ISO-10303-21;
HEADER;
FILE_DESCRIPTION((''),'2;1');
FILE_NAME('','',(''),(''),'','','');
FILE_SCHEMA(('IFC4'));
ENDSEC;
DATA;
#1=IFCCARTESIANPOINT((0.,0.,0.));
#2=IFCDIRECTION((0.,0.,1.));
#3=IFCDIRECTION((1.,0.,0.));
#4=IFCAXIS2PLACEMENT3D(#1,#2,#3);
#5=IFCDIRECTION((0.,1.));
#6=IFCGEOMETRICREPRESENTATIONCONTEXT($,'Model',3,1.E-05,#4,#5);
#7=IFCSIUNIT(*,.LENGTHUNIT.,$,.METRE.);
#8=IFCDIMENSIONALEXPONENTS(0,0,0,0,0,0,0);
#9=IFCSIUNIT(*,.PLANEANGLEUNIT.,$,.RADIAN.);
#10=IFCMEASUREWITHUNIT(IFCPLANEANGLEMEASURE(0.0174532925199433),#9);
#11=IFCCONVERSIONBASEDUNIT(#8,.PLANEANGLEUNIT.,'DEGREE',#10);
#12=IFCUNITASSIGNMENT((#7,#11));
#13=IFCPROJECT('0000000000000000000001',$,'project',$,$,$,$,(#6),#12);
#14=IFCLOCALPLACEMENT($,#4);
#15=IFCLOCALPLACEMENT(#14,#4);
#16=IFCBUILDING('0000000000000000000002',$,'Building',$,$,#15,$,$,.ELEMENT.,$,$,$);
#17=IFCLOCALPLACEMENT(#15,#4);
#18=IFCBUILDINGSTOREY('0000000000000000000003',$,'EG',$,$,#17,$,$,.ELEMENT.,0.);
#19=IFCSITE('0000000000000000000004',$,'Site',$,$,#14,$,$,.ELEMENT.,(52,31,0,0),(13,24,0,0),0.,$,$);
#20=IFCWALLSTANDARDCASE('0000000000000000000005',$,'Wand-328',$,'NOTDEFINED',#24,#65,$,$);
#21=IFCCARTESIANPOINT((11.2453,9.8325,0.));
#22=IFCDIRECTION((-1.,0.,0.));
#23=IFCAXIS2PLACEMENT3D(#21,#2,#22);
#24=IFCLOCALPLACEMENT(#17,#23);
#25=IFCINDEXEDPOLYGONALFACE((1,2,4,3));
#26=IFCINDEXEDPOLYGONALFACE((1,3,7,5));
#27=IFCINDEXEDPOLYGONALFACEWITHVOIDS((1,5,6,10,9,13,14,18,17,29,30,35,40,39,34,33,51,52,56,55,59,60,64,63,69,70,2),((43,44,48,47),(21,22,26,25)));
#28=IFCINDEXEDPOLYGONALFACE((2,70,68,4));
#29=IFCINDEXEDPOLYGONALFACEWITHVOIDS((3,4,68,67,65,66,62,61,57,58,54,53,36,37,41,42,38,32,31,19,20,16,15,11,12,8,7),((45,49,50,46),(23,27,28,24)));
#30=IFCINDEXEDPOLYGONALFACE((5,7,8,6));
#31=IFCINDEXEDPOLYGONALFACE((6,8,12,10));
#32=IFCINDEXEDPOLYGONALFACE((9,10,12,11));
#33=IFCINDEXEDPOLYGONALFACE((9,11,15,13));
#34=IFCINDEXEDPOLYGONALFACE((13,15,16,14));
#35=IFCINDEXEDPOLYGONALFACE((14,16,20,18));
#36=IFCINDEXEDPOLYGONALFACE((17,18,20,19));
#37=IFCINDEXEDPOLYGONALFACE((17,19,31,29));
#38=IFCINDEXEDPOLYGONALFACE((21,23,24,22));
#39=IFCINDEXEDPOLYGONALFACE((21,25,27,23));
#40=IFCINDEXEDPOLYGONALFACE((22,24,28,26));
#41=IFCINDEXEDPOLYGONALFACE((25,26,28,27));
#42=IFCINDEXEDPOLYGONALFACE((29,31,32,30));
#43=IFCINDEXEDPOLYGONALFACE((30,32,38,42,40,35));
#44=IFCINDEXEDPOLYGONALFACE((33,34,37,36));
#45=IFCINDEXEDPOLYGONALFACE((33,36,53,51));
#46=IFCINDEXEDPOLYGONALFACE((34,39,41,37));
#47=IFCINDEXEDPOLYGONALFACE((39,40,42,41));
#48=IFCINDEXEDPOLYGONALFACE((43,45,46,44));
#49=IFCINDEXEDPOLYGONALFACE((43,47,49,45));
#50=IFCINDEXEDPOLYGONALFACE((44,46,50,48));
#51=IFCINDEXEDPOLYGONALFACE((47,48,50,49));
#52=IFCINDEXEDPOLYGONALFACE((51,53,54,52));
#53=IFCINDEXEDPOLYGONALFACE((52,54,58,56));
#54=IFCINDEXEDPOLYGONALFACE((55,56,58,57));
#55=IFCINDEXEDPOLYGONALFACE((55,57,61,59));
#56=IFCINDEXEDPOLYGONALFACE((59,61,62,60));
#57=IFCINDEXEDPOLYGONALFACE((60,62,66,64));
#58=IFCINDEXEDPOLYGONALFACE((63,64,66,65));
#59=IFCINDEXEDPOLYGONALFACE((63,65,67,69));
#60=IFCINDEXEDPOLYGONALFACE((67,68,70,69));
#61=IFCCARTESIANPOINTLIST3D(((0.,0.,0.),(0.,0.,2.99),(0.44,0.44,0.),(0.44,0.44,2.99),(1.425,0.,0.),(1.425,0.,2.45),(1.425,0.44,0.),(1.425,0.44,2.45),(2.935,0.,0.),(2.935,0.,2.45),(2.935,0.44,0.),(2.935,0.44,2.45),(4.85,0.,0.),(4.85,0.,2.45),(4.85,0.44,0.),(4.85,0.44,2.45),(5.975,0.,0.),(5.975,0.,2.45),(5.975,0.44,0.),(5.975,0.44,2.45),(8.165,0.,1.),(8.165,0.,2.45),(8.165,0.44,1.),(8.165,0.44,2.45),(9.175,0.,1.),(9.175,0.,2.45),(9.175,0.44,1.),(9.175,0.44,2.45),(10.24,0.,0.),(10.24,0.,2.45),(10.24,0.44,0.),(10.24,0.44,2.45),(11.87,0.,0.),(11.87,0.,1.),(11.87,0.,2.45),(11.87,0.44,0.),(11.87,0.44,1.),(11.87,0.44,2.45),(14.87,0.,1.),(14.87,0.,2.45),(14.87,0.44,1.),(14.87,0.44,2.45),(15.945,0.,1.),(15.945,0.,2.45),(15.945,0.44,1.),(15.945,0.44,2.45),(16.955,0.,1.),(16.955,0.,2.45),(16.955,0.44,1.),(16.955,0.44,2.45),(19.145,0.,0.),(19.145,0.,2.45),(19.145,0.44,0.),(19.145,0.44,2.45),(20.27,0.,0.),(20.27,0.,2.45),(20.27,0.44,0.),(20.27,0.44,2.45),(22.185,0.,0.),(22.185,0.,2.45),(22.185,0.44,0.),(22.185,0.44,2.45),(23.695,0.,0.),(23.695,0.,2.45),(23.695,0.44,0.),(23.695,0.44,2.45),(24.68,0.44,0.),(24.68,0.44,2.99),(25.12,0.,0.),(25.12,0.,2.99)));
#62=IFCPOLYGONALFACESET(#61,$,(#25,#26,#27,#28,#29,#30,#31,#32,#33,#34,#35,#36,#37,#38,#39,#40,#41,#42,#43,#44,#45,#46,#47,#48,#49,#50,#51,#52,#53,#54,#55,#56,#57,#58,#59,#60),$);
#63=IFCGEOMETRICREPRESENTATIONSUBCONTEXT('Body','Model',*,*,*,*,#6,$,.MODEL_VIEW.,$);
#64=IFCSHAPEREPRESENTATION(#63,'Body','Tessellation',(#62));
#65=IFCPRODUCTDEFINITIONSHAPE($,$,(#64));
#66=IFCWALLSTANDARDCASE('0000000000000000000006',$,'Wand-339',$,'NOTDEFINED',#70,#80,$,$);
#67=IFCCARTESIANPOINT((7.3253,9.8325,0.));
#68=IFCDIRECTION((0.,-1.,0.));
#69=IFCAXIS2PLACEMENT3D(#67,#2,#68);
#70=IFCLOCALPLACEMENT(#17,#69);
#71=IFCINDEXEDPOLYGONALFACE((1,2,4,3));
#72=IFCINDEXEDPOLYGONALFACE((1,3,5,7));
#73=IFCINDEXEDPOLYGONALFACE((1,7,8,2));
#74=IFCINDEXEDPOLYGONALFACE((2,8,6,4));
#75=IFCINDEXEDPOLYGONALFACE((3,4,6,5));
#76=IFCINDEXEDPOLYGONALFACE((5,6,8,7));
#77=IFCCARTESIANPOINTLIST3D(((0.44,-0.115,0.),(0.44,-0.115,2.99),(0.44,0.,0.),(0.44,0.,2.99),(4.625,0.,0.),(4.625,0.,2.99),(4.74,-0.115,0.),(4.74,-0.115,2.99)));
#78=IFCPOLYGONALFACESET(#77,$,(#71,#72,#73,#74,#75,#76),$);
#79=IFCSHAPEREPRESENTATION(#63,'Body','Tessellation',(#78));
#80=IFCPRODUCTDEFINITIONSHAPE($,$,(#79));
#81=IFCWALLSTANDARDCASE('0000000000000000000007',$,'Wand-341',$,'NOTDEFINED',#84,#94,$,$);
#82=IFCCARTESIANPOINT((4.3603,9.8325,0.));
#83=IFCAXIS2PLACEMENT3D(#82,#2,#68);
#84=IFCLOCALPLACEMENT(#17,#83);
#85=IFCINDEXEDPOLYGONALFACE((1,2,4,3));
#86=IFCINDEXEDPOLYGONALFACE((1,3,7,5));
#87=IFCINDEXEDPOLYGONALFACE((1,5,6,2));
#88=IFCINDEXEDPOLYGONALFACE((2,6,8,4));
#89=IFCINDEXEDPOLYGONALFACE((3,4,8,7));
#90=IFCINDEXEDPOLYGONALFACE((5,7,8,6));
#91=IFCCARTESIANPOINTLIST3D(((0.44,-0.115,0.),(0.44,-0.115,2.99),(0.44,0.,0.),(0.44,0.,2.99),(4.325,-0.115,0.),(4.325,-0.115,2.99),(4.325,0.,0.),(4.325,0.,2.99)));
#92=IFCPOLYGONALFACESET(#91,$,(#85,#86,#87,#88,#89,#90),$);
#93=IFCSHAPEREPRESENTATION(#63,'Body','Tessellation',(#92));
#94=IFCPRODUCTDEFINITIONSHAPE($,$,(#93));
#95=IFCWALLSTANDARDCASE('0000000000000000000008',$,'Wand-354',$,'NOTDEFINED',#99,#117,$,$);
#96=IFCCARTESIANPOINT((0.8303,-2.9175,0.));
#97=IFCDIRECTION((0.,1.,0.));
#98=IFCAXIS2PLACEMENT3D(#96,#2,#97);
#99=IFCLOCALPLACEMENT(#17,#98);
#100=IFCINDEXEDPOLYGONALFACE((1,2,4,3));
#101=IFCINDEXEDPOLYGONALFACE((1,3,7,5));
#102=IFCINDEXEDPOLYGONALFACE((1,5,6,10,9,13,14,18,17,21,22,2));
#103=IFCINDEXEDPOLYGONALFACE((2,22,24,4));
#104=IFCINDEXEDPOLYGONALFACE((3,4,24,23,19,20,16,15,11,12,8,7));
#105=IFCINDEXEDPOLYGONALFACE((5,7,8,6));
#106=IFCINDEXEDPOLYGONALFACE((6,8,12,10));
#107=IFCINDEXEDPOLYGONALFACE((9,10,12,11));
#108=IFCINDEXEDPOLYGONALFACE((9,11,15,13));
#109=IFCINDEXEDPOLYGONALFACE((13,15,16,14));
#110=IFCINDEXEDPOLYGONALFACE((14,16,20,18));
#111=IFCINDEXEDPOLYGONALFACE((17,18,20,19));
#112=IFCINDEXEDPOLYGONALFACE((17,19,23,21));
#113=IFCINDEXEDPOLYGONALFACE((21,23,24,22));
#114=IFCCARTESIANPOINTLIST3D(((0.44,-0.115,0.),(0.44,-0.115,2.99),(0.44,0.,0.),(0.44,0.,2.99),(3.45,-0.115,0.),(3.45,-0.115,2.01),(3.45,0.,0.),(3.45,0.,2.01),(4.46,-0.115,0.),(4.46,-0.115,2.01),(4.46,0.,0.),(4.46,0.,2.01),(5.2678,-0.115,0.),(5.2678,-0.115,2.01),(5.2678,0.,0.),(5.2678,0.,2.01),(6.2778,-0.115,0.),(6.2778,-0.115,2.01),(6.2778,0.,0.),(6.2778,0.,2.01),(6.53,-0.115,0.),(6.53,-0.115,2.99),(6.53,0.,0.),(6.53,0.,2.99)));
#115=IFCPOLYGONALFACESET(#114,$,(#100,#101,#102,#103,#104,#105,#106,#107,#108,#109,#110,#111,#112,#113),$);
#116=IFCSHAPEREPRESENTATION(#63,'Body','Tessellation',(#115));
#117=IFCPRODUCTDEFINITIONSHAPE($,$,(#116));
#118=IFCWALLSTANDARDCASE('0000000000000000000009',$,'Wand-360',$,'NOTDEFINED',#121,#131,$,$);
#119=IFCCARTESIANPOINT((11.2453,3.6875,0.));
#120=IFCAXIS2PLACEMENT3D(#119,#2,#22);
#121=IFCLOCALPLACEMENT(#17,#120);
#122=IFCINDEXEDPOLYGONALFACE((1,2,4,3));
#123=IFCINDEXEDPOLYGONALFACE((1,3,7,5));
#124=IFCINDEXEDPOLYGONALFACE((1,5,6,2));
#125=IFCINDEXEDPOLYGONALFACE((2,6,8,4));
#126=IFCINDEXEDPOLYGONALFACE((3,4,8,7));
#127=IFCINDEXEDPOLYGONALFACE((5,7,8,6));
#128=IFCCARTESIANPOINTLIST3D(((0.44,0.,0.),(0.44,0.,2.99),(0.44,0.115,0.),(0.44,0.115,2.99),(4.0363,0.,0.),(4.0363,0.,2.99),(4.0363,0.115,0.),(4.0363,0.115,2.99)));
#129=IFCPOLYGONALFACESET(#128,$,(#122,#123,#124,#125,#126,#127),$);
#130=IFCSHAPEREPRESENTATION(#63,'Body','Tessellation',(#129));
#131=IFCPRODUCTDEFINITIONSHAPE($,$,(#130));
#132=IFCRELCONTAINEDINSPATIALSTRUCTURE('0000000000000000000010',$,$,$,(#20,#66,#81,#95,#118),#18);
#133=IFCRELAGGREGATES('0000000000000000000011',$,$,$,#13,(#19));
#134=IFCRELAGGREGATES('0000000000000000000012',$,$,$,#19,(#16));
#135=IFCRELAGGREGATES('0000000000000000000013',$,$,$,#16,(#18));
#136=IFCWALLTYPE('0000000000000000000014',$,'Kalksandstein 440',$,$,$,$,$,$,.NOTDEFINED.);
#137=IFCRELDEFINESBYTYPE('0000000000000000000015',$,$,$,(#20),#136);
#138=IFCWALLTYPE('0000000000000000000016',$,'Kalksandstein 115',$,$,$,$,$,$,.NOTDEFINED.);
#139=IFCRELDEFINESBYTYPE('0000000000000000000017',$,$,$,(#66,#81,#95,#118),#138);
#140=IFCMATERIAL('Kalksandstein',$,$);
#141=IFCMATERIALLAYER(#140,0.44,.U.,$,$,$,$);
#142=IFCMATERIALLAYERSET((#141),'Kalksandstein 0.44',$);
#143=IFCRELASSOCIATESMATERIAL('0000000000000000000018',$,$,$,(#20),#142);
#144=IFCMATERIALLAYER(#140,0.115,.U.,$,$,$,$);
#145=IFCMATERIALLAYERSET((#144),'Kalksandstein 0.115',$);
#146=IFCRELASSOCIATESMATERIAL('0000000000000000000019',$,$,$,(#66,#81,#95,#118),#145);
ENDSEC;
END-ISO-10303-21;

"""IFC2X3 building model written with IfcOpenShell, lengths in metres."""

from ifc_helpers import new_model, entity, si_unit, converted_unit, direction, frame, origin_with_axes, origin_2d_with_axis, place, context, subcontext, project, spatial, polyline, rectangle, outline, extrude, material, layer, layer_set, layer_usage, type_object, element, save


model = new_model("IFC2X3")

# Units and contexts
model_context = context("Model", 3, precision=1e-05, world=origin_with_axes(), true_north=direction((0.0, 1.0)))
body_context = subcontext(model_context, "Body", "Model", "MODEL_VIEW")
ifc_project = project(units=[si_unit("LENGTHUNIT", "METRE"), converted_unit("PLANEANGLEUNIT", "DEGREE", entity("IfcPlaneAngleMeasure", 0.0174532925199433), si_unit("PLANEANGLEUNIT", "RADIAN"), dimensions=[0, 0, 0, 0, 0, 0, 0])], contexts=[model_context])

# Site, building, storey
site_placement = place(None, origin_with_axes())
site = spatial("IfcSite", under=ifc_project, at=site_placement, Name="Site", CompositionType="ELEMENT", RefLatitude=(52, 31, 0, 0), RefLongitude=(13, 24, 0, 0), RefElevation=0.0)
building_placement = place(site_placement, origin_with_axes())
building = spatial("IfcBuilding", under=site, at=building_placement, Name="Building", CompositionType="ELEMENT")
storey_placement = place(building_placement, origin_with_axes())
storey = spatial("IfcBuildingStorey", under=building, at=storey_placement, Name="EG", CompositionType="ELEMENT", Elevation=0.0)

# Wall, openings
ifc_material = material(Name="Kalksandstein")
ifc_layer_1 = layer(ifc_material, 0.44, ventilated="UNKNOWN")
ifc_layer_set_1 = layer_set([ifc_layer_1], Name="Kalksandstein 0.44")
ifc_layer_usage_1 = layer_usage(ifc_layer_set_1, "AXIS2", "NEGATIVE", 0.44)
wall_type_1 = type_object("IfcWallType", Name="Kalksandstein 440", PredefinedType="NOTDEFINED")
wall_1_placement = place(storey_placement, frame((11.2453, 9.8325, 0.0), z_axis=(0.0, 0.0, 1.0), x_axis=(-1.0, 0.0, 0.0)))
wall_1 = element("IfcWallStandardCase", 1, at=wall_1_placement, inside=storey, type_object=wall_type_1, material=ifc_layer_usage_1, Name="Wand-328", ObjectType="NOTDEFINED", context=body_context, shape_type="SweptSolid", body=[
    extrude(outline(polyline([(0.0, 0.0), (25.12, 0.0), (24.68, 0.44), (0.44, 0.44), (0.0, 0.0)])), origin_with_axes(), (0.0, 0.0, 1.0), 2.99),
])
opening_1_placement = place(wall_1_placement, frame((5.4125, 0.0, 0.0), z_axis=(0.0, 0.0, 1.0), x_axis=(1.0, 0.0, 0.0)))
element("IfcOpeningElement", 2, at=opening_1_placement, cuts=wall_1, context=body_context, shape_type="SweptSolid", body=[
    extrude(rectangle(XDim=1.125, YDim=2.45, at=origin_2d_with_axis()), frame((0.0, 0.44, 1.225), z_axis=(0.0, -1.0, 0.0), x_axis=(-1.0, 0.0, 0.0)), (0.0, 0.0, 1.0), 1.32),
])
opening_2_placement = place(wall_1_placement, frame((2.18, 0.0, 0.0), z_axis=(0.0, 0.0, 1.0), x_axis=(1.0, 0.0, 0.0)))
element("IfcOpeningElement", 3, at=opening_2_placement, cuts=wall_1, context=body_context, shape_type="SweptSolid", body=[
    extrude(rectangle(XDim=1.51, YDim=2.45, at=origin_2d_with_axis()), frame((0.0, 0.44, 1.225), z_axis=(0.0, -1.0, 0.0), x_axis=(-1.0, 0.0, 0.0)), (0.0, 0.0, 1.0), 1.32),
])
opening_3_placement = place(wall_1_placement, frame((8.67, 0.0, 1.0), z_axis=(0.0, 0.0, 1.0), x_axis=(1.0, 0.0, 0.0)))
element("IfcOpeningElement", 4, at=opening_3_placement, cuts=wall_1, context=body_context, shape_type="SweptSolid", body=[
    extrude(rectangle(XDim=1.01, YDim=1.45, at=origin_2d_with_axis()), frame((0.0, 0.44, 0.725), z_axis=(0.0, -1.0, 0.0), x_axis=(-1.0, 0.0, 0.0)), (0.0, 0.0, 1.0), 1.32),
])
opening_4_placement = place(wall_1_placement, frame((19.7075, 0.0, 0.0), z_axis=(0.0, 0.0, 1.0), x_axis=(1.0, 0.0, 0.0)))
element("IfcOpeningElement", 5, at=opening_4_placement, cuts=wall_1, context=body_context, shape_type="SweptSolid", body=[
    extrude(rectangle(XDim=1.125, YDim=2.45, at=origin_2d_with_axis()), frame((0.0, 0.44, 1.225), z_axis=(0.0, -1.0, 0.0), x_axis=(-1.0, 0.0, 0.0)), (0.0, 0.0, 1.0), 1.32),
])
opening_5_placement = place(wall_1_placement, frame((13.37, 0.0, 1.0), z_axis=(0.0, 0.0, 1.0), x_axis=(1.0, 0.0, 0.0)))
element("IfcOpeningElement", 6, at=opening_5_placement, cuts=wall_1, context=body_context, shape_type="SweptSolid", body=[
    extrude(rectangle(XDim=3.0, YDim=1.45, at=origin_2d_with_axis()), frame((0.0, 0.44, 0.725), z_axis=(0.0, -1.0, 0.0), x_axis=(-1.0, 0.0, 0.0)), (0.0, 0.0, 1.0), 1.32),
])
opening_6_placement = place(wall_1_placement, frame((16.45, 0.0, 1.0), z_axis=(0.0, 0.0, 1.0), x_axis=(1.0, 0.0, 0.0)))
element("IfcOpeningElement", 7, at=opening_6_placement, cuts=wall_1, context=body_context, shape_type="SweptSolid", body=[
    extrude(rectangle(XDim=1.01, YDim=1.45, at=origin_2d_with_axis()), frame((0.0, 0.44, 0.725), z_axis=(0.0, -1.0, 0.0), x_axis=(-1.0, 0.0, 0.0)), (0.0, 0.0, 1.0), 1.32),
])
opening_7_placement = place(wall_1_placement, frame((22.94, 0.0, 0.0), z_axis=(0.0, 0.0, 1.0), x_axis=(1.0, 0.0, 0.0)))
element("IfcOpeningElement", 8, at=opening_7_placement, cuts=wall_1, context=body_context, shape_type="SweptSolid", body=[
    extrude(rectangle(XDim=1.51, YDim=2.45, at=origin_2d_with_axis()), frame((0.0, 0.44, 1.225), z_axis=(0.0, -1.0, 0.0), x_axis=(-1.0, 0.0, 0.0)), (0.0, 0.0, 1.0), 1.32),
])
opening_8_placement = place(wall_1_placement, frame((11.055, 0.0, 0.0), z_axis=(0.0, 0.0, 1.0), x_axis=(1.0, 0.0, 0.0)))
element("IfcOpeningElement", 9, at=opening_8_placement, cuts=wall_1, context=body_context, shape_type="SweptSolid", body=[
    extrude(rectangle(XDim=1.63, YDim=2.45, at=origin_2d_with_axis()), frame((0.0, 0.44, 1.225), z_axis=(0.0, 1.0, 0.0), x_axis=(-1.0, 0.0, 0.0)), (0.0, 0.0, -1.0), 1.32),
])

# Walls
ifc_layer_2 = layer(ifc_material, 0.115, ventilated="UNKNOWN")
ifc_layer_set_2 = layer_set([ifc_layer_2], Name="Kalksandstein 0.115")
ifc_layer_usage_2 = layer_usage(ifc_layer_set_2, "AXIS2", "POSITIVE", -0.115)
wall_type_2 = type_object("IfcWallType", Name="Kalksandstein 115", PredefinedType="NOTDEFINED")
wall_2_placement = place(storey_placement, frame((7.3253, 9.8325, 0.0), z_axis=(0.0, 0.0, 1.0), x_axis=(0.0, -1.0, 0.0)))
element("IfcWallStandardCase", 10, at=wall_2_placement, inside=storey, type_object=wall_type_2, material=ifc_layer_usage_2, Name="Wand-339", ObjectType="NOTDEFINED", context=body_context, shape_type="SweptSolid", body=[
    extrude(outline(polyline([(0.44, -0.115), (4.74, -0.115), (4.625, 0.0), (0.44, 0.0), (0.44, -0.115)])), origin_with_axes(), (0.0, 0.0, 1.0), 2.99),
])
ifc_layer_usage_3 = layer_usage(ifc_layer_set_2, "AXIS2", "POSITIVE", -0.115)
wall_3_placement = place(storey_placement, frame((4.3603, 9.8325, 0.0), z_axis=(0.0, 0.0, 1.0), x_axis=(0.0, -1.0, 0.0)))
element("IfcWallStandardCase", 11, at=wall_3_placement, inside=storey, type_object=wall_type_2, material=ifc_layer_usage_3, Name="Wand-341", ObjectType="NOTDEFINED", context=body_context, shape_type="SweptSolid", body=[
    extrude(outline(polyline([(0.44, -0.115), (4.325, -0.115), (4.325, 0.0), (0.44, 0.0), (0.44, -0.115)])), origin_with_axes(), (0.0, 0.0, 1.0), 2.99),
])

# Wall, openings
ifc_layer_usage_4 = layer_usage(ifc_layer_set_2, "AXIS2", "POSITIVE", -0.115)
wall_4_placement = place(storey_placement, frame((0.8303, -2.9175, 0.0), z_axis=(0.0, 0.0, 1.0), x_axis=(0.0, 1.0, 0.0)))
wall_4 = element("IfcWallStandardCase", 12, at=wall_4_placement, inside=storey, type_object=wall_type_2, material=ifc_layer_usage_4, Name="Wand-354", ObjectType="NOTDEFINED", context=body_context, shape_type="SweptSolid", body=[
    extrude(outline(polyline([(0.44, -0.115), (6.53, -0.115), (6.53, 0.0), (0.44, 0.0), (0.44, -0.115)])), origin_with_axes(), (0.0, 0.0, 1.0), 2.99),
])
opening_9_placement = place(wall_4_placement, frame((3.955, 0.0, 0.0), z_axis=(0.0, 0.0, 1.0), x_axis=(1.0, 0.0, 0.0)))
element("IfcOpeningElement", 13, at=opening_9_placement, cuts=wall_4, context=body_context, shape_type="SweptSolid", body=[
    extrude(rectangle(XDim=1.01, YDim=2.01, at=origin_2d_with_axis()), frame((0.0, 0.115, 1.005), z_axis=(0.0, 1.0, 0.0), x_axis=(1.0, 0.0, 0.0)), (0.0, 0.0, -1.0), 0.345),
])
opening_10_placement = place(wall_4_placement, frame((5.7728, 0.0, 0.0), z_axis=(0.0, 0.0, 1.0), x_axis=(1.0, 0.0, 0.0)))
element("IfcOpeningElement", 14, at=opening_10_placement, cuts=wall_4, context=body_context, shape_type="SweptSolid", body=[
    extrude(rectangle(XDim=1.01, YDim=2.01, at=origin_2d_with_axis()), frame((0.0, -0.115, 1.005), z_axis=(0.0, 1.0, 0.0), x_axis=(1.0, 0.0, 0.0)), (0.0, 0.0, 1.0), 0.345),
])

# Wall
ifc_layer_usage_5 = layer_usage(ifc_layer_set_2, "AXIS2", "NEGATIVE", 0.115)
wall_5_placement = place(storey_placement, frame((11.2453, 3.6875, 0.0), z_axis=(0.0, 0.0, 1.0), x_axis=(-1.0, 0.0, 0.0)))
element("IfcWallStandardCase", 15, at=wall_5_placement, inside=storey, type_object=wall_type_2, material=ifc_layer_usage_5, Name="Wand-360", ObjectType="NOTDEFINED", context=body_context, shape_type="SweptSolid", body=[
    extrude(outline(polyline([(0.44, 0.0), (4.0363, 0.0), (4.0363, 0.115), (0.44, 0.115), (0.44, 0.0)])), origin_with_axes(), (0.0, 0.0, 1.0), 2.99),
])

save(model, "model.ifc")
